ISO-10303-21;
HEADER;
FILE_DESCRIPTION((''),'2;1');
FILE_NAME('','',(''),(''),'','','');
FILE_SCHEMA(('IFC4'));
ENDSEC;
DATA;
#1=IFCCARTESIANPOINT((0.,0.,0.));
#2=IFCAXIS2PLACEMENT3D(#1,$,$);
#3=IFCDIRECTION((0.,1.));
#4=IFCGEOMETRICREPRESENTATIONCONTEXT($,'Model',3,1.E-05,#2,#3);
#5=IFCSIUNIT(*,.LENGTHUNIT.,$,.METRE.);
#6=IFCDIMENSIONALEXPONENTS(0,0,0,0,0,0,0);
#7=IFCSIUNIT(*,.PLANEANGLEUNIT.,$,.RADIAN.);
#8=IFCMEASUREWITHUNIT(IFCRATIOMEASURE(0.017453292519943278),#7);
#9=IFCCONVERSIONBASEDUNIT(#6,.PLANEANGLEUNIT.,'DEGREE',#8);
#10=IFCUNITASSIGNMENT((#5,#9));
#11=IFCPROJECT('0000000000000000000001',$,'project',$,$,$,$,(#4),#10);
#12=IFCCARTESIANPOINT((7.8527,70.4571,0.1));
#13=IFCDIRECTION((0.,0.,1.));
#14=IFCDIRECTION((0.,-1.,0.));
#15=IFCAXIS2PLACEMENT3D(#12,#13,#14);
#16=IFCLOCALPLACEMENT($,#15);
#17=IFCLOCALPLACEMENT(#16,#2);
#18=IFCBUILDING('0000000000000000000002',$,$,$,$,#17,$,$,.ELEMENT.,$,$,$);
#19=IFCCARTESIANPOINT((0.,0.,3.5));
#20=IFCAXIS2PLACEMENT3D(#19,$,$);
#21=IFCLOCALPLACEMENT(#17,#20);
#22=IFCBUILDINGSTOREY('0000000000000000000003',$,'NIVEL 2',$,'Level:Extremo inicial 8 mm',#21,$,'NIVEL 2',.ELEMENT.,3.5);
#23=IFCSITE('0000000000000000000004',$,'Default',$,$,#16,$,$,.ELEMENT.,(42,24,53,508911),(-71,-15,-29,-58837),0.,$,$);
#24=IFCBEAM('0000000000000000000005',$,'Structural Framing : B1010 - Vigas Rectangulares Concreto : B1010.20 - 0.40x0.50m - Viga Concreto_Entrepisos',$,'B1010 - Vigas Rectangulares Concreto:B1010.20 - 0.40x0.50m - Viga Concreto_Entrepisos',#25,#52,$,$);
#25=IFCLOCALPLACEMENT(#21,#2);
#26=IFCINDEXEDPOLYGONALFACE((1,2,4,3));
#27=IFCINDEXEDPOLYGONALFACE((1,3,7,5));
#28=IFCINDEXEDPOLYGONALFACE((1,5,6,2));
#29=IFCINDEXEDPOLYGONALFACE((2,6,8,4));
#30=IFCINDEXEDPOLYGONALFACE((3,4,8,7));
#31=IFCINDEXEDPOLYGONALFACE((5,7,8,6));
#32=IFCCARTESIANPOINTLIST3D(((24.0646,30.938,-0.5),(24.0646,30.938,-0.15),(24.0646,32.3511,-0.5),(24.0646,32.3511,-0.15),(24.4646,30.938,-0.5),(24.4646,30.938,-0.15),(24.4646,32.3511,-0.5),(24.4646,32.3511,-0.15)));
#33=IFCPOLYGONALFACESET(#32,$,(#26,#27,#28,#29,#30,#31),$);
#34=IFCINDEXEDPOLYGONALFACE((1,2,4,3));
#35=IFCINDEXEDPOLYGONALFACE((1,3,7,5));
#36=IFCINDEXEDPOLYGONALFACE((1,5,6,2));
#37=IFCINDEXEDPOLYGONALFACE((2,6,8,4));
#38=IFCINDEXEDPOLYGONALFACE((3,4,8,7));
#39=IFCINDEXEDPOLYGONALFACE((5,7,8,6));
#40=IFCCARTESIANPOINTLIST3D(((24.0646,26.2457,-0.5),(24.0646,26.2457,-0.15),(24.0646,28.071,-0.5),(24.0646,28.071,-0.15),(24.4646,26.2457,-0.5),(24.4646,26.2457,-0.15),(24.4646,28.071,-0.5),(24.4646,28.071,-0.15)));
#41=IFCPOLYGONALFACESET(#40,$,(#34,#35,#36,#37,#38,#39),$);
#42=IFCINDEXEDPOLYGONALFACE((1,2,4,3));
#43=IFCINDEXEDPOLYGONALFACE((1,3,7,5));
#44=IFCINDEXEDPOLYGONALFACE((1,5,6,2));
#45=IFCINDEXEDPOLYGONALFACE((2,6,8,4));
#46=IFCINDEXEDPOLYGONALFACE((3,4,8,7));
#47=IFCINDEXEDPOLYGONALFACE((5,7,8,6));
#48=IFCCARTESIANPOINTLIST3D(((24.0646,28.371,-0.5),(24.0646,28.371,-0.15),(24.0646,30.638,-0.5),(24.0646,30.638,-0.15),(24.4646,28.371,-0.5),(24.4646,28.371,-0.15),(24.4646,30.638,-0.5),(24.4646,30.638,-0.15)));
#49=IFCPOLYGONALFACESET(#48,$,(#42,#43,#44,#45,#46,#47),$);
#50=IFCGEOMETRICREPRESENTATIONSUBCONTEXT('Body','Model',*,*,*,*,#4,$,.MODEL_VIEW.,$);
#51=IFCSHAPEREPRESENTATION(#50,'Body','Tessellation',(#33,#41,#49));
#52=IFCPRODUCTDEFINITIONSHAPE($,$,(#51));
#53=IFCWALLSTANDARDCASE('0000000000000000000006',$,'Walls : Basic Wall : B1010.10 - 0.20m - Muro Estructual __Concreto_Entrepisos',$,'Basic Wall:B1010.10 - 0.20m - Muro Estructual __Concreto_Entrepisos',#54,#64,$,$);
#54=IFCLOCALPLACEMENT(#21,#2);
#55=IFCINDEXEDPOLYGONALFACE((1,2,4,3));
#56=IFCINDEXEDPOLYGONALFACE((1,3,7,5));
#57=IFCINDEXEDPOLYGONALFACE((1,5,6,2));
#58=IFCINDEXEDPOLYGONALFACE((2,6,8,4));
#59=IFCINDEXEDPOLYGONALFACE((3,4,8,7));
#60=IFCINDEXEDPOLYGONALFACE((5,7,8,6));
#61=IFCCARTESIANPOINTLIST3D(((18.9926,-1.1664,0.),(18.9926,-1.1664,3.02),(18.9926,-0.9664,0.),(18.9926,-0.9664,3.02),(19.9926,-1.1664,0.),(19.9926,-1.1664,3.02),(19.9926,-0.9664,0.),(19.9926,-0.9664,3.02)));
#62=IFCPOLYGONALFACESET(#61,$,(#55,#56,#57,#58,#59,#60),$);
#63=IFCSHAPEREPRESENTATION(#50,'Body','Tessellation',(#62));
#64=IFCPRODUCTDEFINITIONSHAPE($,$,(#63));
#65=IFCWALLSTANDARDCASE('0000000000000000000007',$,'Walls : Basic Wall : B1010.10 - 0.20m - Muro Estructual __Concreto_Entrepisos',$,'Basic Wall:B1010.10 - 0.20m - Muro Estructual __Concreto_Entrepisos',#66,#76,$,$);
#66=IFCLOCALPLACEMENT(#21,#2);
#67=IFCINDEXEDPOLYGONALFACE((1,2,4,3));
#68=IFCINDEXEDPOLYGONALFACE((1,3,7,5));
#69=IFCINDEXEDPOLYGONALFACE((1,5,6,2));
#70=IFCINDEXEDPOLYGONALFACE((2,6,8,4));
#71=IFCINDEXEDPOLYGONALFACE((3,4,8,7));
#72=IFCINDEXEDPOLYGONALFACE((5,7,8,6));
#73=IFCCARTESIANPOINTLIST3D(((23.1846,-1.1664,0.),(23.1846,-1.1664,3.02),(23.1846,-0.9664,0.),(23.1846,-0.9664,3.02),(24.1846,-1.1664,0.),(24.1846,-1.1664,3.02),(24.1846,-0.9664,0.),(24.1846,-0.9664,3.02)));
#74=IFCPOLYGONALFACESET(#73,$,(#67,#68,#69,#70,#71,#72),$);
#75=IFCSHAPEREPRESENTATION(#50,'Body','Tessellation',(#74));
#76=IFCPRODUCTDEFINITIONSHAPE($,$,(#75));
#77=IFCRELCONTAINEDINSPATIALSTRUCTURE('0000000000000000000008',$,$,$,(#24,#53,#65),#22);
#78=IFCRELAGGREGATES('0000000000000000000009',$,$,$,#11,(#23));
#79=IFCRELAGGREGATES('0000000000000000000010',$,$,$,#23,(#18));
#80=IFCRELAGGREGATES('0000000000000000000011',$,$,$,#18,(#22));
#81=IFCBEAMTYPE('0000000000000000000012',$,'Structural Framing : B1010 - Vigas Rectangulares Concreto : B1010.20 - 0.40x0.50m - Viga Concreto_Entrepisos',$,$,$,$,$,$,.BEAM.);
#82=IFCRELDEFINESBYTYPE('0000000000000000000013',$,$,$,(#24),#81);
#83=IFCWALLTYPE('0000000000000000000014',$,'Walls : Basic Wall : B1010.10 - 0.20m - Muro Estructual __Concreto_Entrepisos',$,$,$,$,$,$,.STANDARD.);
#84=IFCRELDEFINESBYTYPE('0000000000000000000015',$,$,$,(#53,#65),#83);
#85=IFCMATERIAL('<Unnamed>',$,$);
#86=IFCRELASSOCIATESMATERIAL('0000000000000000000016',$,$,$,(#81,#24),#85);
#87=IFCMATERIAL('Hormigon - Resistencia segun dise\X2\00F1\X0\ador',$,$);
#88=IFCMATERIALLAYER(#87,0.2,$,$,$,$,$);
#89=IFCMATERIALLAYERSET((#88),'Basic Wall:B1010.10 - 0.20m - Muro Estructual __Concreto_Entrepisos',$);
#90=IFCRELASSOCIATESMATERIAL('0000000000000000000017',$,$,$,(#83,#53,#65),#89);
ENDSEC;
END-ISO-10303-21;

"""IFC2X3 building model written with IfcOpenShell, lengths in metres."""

from ifc_helpers import new_model, entity, si_unit, converted_unit, direction, frame, frame_2d, origin, place, context, subcontext, project, spatial, rectangle, extrude, source, transform, mapped, material, layer, layer_set, layer_usage, type_object, type_shapes, element, save


model = new_model("IFC2X3")

# Units and contexts
model_context = context("Model", 3, precision=1e-05, world=origin(), true_north=direction((0.0, 1.0)))
body_context = subcontext(model_context, "Body", "Model", "MODEL_VIEW")
ifc_project = project(units=[si_unit("LENGTHUNIT", "METRE"), converted_unit("PLANEANGLEUNIT", "DEGREE", entity("IfcRatioMeasure", 0.017453292519943278), si_unit("PLANEANGLEUNIT", "RADIAN"), dimensions=[0, 0, 0, 0, 0, 0, 0])], contexts=[model_context])

# Site, building, storey
site_placement = place(None, frame((7.8527, 70.4571, 0.1), z_axis=(0.0, 0.0, 1.0), x_axis=(0.0, -1.0, 0.0)))
site = spatial("IfcSite", under=ifc_project, at=site_placement, Name="Default", CompositionType="ELEMENT", RefLatitude=(42, 24, 53, 508911), RefLongitude=(-71, -15, -29, -58837), RefElevation=0.0)
building_placement = place(site_placement, origin())
building = spatial("IfcBuilding", under=site, at=building_placement, CompositionType="ELEMENT")
storey_placement = place(building_placement, frame((0.0, 0.0, 3.5)))
storey = spatial("IfcBuildingStorey", under=building, at=storey_placement, Name="NIVEL 2", ObjectType="Level:Extremo inicial 8 mm", LongName="NIVEL 2", CompositionType="ELEMENT", Elevation=3.5)

# Shared definitions
ifc_material_1 = material(Name="<Unnamed>")

# Beam
beam_type_1 = type_object("IfcBeamType", Name="Structural Framing : B1010 - Vigas Rectangulares Concreto : B1010.20 - 0.40x0.50m - Viga Concreto_Entrepisos", PredefinedType="BEAM", material=ifc_material_1)
shared_shape_1 = source(origin(), body_context, "Body", "SweptSolid", [
    extrude(rectangle(XDim=0.35, YDim=0.4, at=frame_2d((0.0, 0.0), x_axis=(0.0, 1.0))), frame((24.2646, 30.938, 3.175), z_axis=(0.0, 1.0, 0.0), x_axis=(-1.0, 0.0, 0.0)), (0.0, 0.0, 1.0), 1.413),
    extrude(rectangle(XDim=0.35, YDim=0.4, at=frame_2d((0.0, 0.0), x_axis=(0.0, 1.0))), frame((24.2646, 26.2457, 3.175), z_axis=(0.0, 1.0, 0.0), x_axis=(-1.0, 0.0, 0.0)), (0.0, 0.0, 1.0), 1.8253),
    extrude(rectangle(XDim=0.35, YDim=0.4, at=frame_2d((0.0, 0.0), x_axis=(0.0, 1.0))), frame((24.2646, 28.371, 3.175), z_axis=(0.0, 1.0, 0.0), x_axis=(-1.0, 0.0, 0.0)), (0.0, 0.0, 1.0), 2.2671),
])
type_shapes(beam_type_1, [shared_shape_1])
beam_1_placement = place(storey_placement, frame((0.0, 0.0, -3.5)))
element("IfcBeam", 1, at=beam_1_placement, inside=storey, type_object=beam_type_1, material=ifc_material_1, Name="Structural Framing : B1010 - Vigas Rectangulares Concreto : B1010.20 - 0.40x0.50m - Viga Concreto_Entrepisos", ObjectType="B1010 - Vigas Rectangulares Concreto:B1010.20 - 0.40x0.50m - Viga Concreto_Entrepisos", context=body_context, shape_type="MappedRepresentation", body=[
    mapped(shared_shape_1, transform((0.0, 0.0, 0.0), scale=1.0)),
])

# Shared definitions
ifc_material_2 = material(Name="Hormigon - Resistencia segun diseñador")

# Walls
ifc_layer_1 = layer(ifc_material_2, 0.2)
ifc_layer_set_1 = layer_set([ifc_layer_1], Name="Basic Wall:B1010.10 - 0.20m - Muro Estructual __Concreto_Entrepisos")
ifc_layer_usage_1 = layer_usage(ifc_layer_set_1, "AXIS2", "NEGATIVE", 0.1)
wall_type = type_object("IfcWallType", Name="Walls : Basic Wall : B1010.10 - 0.20m - Muro Estructual __Concreto_Entrepisos", PredefinedType="STANDARD", material=ifc_layer_set_1)
wall_1_placement = place(storey_placement, frame((18.9926, -1.0664, 0.0)))
element("IfcWallStandardCase", 2, at=wall_1_placement, inside=storey, type_object=wall_type, material=ifc_layer_usage_1, Name="Walls : Basic Wall : B1010.10 - 0.20m - Muro Estructual __Concreto_Entrepisos", ObjectType="Basic Wall:B1010.10 - 0.20m - Muro Estructual __Concreto_Entrepisos", context=body_context, shape_type="SweptSolid", body=[
    extrude(rectangle(XDim=1.0, YDim=0.2, at=frame_2d((0.5, 0.0), x_axis=(-1.0, 0.0))), origin(), (0.0, 0.0, 1.0), 3.02),
])
ifc_layer_usage_2 = layer_usage(ifc_layer_set_1, "AXIS2", "NEGATIVE", 0.1)
wall_2_placement = place(storey_placement, frame((23.1846, -1.0664, 0.0)))
element("IfcWallStandardCase", 3, at=wall_2_placement, inside=storey, type_object=wall_type, material=ifc_layer_usage_2, Name="Walls : Basic Wall : B1010.10 - 0.20m - Muro Estructual __Concreto_Entrepisos", ObjectType="Basic Wall:B1010.10 - 0.20m - Muro Estructual __Concreto_Entrepisos", context=body_context, shape_type="SweptSolid", body=[
    extrude(rectangle(XDim=1.0, YDim=0.2, at=frame_2d((0.5, 0.0), x_axis=(-1.0, 0.0))), origin(), (0.0, 0.0, 1.0), 3.02),
])

save(model, "model.ifc")
